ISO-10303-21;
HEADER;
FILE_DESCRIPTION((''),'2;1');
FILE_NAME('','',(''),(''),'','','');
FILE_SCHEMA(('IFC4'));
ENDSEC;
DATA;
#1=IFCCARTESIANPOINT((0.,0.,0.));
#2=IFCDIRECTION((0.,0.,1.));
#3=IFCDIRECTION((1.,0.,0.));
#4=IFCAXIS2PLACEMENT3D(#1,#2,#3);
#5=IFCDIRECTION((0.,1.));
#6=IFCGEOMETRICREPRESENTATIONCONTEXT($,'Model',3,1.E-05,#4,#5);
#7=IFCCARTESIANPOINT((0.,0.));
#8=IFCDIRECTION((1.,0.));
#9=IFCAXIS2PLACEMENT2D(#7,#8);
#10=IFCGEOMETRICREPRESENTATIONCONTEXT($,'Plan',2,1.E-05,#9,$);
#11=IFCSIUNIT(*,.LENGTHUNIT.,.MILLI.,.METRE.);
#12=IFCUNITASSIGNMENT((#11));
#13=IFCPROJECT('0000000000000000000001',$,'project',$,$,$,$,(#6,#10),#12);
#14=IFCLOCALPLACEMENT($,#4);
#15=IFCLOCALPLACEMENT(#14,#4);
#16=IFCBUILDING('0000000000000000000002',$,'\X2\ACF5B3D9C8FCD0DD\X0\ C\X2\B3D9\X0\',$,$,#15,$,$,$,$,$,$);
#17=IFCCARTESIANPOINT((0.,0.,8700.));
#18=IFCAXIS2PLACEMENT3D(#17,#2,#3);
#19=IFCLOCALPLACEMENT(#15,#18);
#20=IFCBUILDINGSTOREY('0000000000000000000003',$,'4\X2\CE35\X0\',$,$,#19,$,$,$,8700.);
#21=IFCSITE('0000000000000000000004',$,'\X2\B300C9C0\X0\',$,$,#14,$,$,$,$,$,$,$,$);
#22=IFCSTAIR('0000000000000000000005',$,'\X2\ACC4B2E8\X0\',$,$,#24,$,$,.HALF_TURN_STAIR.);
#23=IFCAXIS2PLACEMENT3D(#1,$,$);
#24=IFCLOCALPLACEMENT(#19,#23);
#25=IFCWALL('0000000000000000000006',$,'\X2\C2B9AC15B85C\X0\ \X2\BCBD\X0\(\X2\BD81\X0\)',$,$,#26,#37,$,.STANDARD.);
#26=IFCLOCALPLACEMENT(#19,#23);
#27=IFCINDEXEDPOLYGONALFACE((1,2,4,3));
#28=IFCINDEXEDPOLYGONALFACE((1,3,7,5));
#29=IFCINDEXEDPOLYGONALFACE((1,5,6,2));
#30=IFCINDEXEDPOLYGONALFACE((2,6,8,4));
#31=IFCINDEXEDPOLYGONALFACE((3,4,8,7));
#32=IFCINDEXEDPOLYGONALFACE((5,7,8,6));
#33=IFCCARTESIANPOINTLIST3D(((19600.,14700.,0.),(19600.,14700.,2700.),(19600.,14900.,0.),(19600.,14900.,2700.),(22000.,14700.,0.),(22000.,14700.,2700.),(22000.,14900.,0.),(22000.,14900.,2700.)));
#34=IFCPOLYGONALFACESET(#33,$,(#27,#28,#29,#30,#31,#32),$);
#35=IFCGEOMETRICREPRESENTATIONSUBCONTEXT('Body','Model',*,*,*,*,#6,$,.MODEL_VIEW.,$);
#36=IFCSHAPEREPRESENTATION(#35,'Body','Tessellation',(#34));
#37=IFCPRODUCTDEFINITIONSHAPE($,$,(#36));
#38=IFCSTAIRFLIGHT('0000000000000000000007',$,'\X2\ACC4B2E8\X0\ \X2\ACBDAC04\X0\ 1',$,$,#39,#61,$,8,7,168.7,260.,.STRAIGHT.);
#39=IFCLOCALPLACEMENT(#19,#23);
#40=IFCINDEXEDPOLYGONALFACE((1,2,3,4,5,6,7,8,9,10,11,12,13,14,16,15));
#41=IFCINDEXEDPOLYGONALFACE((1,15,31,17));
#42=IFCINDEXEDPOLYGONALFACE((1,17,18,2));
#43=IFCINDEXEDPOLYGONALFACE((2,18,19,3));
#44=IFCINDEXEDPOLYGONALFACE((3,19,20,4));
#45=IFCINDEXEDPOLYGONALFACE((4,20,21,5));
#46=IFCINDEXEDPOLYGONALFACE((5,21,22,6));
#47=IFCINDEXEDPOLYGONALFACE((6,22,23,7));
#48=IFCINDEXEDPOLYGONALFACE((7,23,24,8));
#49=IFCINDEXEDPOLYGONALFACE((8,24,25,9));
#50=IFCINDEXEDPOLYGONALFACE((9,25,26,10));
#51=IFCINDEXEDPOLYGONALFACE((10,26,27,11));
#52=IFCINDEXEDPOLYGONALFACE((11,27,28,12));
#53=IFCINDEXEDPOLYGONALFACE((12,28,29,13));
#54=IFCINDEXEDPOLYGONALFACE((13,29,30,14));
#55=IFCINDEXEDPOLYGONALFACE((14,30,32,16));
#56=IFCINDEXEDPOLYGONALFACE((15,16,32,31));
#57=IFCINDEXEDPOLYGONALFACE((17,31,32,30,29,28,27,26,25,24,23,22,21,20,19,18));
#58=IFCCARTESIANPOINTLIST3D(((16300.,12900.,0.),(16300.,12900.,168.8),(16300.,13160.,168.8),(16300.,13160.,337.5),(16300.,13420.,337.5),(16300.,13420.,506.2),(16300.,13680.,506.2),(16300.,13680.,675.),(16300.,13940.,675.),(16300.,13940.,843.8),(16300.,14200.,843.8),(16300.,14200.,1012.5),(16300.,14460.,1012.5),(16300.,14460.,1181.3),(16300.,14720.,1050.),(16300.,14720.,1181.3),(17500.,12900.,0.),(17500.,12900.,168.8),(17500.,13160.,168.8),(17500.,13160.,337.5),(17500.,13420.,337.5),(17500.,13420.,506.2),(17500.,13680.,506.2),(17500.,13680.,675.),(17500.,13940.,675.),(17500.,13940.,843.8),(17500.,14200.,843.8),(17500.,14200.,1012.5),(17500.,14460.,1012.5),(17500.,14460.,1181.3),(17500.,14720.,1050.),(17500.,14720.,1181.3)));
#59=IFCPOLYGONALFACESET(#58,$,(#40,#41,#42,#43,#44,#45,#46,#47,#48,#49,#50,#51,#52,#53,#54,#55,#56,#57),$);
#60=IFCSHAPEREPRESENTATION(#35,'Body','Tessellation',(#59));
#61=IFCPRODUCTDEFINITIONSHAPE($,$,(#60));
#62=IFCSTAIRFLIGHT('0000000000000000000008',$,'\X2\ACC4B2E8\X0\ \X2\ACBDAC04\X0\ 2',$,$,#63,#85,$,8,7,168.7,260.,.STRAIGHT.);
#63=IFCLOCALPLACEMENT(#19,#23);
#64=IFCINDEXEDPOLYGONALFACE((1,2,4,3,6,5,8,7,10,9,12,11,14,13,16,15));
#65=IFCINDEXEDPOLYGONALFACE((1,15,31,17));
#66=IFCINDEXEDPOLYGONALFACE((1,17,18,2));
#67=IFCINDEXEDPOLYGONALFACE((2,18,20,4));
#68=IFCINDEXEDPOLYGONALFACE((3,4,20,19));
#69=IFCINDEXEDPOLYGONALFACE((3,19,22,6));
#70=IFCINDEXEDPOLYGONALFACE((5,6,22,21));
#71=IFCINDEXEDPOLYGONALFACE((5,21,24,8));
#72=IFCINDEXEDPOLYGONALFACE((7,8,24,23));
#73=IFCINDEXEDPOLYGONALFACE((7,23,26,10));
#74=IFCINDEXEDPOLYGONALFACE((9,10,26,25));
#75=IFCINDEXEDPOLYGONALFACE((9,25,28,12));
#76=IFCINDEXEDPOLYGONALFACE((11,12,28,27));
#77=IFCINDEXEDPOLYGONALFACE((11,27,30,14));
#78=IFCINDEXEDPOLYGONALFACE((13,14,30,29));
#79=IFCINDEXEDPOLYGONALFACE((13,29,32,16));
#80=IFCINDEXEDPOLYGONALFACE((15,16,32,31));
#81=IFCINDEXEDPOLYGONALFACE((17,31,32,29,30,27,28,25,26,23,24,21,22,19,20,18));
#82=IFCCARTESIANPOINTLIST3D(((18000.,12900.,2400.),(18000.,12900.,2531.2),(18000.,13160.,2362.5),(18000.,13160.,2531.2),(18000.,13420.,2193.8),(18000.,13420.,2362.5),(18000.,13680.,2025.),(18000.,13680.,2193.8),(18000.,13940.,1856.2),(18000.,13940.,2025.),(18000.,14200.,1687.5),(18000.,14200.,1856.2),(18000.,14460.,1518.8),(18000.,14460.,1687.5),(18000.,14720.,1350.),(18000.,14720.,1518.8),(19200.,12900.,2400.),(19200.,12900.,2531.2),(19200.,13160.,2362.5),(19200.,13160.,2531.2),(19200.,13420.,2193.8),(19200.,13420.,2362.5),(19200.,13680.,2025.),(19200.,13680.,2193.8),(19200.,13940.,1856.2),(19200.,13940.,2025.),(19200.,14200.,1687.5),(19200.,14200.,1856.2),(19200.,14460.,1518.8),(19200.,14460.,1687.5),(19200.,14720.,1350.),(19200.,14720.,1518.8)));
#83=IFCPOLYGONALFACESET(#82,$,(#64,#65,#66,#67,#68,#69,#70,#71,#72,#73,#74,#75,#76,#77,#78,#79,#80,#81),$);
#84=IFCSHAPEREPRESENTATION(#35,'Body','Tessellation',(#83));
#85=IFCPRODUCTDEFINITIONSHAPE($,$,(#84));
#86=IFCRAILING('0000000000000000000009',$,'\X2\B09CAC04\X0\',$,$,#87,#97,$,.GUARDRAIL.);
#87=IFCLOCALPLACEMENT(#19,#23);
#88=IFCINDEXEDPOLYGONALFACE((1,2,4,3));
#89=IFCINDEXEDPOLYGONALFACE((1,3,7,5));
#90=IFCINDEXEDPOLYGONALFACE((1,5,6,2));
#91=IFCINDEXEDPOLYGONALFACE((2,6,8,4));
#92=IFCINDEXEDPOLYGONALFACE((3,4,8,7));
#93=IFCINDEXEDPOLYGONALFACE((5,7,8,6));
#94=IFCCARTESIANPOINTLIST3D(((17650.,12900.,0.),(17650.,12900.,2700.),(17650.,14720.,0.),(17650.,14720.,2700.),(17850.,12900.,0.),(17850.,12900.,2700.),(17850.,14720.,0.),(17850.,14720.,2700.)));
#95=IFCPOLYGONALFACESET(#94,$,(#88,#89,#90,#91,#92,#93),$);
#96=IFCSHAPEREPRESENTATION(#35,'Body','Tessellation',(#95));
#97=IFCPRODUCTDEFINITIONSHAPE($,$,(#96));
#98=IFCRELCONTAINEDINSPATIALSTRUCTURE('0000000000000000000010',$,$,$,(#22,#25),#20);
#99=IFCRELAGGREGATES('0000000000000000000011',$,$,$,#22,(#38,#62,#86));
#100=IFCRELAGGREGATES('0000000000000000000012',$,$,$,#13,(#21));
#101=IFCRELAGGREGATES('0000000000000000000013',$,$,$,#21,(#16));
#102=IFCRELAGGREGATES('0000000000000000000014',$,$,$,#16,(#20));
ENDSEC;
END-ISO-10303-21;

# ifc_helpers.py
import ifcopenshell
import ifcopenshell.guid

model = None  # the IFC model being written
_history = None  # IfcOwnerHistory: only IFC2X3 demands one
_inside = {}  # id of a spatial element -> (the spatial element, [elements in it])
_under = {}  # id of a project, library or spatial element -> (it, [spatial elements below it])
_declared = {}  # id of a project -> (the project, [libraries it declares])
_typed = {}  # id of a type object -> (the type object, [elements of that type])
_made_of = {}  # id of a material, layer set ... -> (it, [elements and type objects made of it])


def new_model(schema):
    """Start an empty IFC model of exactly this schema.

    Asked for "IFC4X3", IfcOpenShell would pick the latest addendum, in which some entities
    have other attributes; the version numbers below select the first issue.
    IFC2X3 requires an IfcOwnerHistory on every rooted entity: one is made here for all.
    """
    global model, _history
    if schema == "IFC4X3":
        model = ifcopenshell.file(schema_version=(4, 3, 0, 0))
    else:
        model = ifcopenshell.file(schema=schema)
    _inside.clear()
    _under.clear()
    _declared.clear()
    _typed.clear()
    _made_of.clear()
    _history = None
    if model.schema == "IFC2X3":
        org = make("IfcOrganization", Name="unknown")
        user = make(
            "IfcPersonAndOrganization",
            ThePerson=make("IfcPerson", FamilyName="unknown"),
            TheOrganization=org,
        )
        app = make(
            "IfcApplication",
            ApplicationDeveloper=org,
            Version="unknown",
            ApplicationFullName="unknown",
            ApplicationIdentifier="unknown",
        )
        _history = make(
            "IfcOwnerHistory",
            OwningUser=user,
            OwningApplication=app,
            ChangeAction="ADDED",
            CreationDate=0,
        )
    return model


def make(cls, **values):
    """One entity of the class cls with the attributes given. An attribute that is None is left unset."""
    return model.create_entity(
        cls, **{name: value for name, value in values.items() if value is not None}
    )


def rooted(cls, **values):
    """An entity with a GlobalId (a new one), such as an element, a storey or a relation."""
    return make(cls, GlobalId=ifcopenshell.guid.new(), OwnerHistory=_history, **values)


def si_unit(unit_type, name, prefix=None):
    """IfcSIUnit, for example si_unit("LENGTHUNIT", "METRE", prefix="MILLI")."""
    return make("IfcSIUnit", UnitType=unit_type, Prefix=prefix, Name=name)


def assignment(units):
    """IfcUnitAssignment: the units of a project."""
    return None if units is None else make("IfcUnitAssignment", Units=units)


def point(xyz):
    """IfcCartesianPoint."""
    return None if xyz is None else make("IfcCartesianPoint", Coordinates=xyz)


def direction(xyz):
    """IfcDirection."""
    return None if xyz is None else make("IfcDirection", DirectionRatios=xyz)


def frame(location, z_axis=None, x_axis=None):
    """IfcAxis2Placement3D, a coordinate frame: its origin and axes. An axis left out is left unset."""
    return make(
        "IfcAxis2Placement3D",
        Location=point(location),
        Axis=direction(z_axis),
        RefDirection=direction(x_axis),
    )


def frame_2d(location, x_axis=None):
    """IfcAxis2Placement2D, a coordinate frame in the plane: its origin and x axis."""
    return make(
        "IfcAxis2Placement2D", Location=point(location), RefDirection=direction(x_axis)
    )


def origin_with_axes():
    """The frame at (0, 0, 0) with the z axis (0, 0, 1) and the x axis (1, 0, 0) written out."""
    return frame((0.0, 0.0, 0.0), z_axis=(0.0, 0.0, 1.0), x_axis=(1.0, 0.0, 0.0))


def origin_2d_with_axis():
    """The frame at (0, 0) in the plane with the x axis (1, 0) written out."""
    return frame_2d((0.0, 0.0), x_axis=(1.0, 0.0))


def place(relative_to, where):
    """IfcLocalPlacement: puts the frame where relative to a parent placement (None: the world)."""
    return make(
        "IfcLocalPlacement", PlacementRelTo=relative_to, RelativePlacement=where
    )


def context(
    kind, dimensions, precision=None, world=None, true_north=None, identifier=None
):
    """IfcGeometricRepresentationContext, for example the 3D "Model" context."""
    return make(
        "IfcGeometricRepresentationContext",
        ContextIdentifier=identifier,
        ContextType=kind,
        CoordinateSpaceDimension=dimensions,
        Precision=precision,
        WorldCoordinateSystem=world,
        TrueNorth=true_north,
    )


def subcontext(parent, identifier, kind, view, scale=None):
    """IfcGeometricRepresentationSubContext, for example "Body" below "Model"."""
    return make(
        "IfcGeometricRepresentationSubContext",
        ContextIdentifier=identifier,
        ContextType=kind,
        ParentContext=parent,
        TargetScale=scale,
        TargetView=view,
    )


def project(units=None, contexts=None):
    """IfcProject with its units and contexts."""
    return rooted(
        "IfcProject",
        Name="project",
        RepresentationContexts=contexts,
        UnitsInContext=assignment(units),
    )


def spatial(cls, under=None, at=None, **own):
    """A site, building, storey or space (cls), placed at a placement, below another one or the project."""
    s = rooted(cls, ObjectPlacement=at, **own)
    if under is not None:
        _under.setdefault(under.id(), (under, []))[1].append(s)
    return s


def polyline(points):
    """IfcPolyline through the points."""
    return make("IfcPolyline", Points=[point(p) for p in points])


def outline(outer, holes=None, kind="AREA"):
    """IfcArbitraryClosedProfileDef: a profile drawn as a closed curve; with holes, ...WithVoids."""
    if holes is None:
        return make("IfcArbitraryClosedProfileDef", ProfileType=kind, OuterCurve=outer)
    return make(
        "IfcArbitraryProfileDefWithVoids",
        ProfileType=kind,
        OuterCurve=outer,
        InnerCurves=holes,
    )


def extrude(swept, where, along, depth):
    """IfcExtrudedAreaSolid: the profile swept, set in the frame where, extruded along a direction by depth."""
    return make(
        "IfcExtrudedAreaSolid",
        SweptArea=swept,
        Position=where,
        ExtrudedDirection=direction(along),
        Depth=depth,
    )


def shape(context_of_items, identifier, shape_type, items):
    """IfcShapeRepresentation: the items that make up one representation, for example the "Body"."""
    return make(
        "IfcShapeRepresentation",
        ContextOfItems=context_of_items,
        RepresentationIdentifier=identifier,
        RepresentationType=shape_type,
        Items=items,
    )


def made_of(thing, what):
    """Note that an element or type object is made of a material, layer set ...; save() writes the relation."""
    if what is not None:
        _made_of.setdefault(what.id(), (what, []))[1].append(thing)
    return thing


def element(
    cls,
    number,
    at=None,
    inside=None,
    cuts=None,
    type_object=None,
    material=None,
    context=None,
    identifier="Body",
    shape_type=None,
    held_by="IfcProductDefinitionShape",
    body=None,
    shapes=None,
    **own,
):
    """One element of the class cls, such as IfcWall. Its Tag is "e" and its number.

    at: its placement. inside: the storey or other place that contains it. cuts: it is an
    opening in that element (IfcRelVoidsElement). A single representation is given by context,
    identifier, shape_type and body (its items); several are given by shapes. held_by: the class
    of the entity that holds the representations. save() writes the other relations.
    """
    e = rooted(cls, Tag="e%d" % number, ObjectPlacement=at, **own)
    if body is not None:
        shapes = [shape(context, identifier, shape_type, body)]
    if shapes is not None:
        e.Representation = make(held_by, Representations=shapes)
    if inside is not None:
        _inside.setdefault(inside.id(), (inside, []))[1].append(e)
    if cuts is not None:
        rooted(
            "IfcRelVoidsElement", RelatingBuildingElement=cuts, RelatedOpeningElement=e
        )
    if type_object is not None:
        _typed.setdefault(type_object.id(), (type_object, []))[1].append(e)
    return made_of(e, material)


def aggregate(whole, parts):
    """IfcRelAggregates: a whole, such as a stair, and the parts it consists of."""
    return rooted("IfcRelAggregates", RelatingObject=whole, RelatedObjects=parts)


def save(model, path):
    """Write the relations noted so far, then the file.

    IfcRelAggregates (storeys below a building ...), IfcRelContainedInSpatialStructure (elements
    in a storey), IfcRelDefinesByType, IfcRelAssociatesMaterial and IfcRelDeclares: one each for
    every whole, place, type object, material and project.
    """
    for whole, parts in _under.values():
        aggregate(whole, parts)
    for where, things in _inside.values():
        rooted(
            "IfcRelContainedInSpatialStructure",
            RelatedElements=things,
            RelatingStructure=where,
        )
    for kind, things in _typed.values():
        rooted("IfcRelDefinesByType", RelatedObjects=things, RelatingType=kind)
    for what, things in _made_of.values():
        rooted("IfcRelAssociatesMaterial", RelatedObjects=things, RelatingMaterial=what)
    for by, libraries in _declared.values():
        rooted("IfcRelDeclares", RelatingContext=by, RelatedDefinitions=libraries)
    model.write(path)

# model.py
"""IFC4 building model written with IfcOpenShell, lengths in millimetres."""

from ifc_helpers import new_model, si_unit, direction, frame, origin_with_axes, origin_2d_with_axis, place, context, subcontext, project, spatial, polyline, outline, extrude, element, aggregate, save


model = new_model("IFC4")

# Units and contexts
model_context = context("Model", 3, precision=1e-05, world=origin_with_axes(), true_north=direction((0.0, 1.0)))
plan_context = context("Plan", 2, precision=1e-05, world=origin_2d_with_axis())
body_context = subcontext(model_context, "Body", "Model", "MODEL_VIEW")
ifc_project = project(units=[si_unit("LENGTHUNIT", "METRE", prefix="MILLI")], contexts=[model_context, plan_context])

# Site, building, storey
site_placement = place(None, origin_with_axes())
site = spatial("IfcSite", under=ifc_project, at=site_placement, Name="대지")
building_placement = place(site_placement, origin_with_axes())
building = spatial("IfcBuilding", under=site, at=building_placement, Name="공동주택 C동")
storey_placement = place(building_placement, frame((0.0, 0.0, 8700.0), z_axis=(0.0, 0.0, 1.0), x_axis=(1.0, 0.0, 0.0)))
storey = spatial("IfcBuildingStorey", under=building, at=storey_placement, Name="4층", Elevation=8700.0)

# Stair
stair_placement = place(storey_placement, origin_with_axes())
stair = element("IfcStair", 1, at=stair_placement, inside=storey, Name="계단", PredefinedType="HALF_TURN_STAIR")

# Wall
wall_1_placement = place(storey_placement, origin_with_axes())
element("IfcWall", 2, at=wall_1_placement, inside=storey, Name="승강로 벽(북)", PredefinedType="STANDARD", context=body_context, shape_type="SweptSolid", body=[
    extrude(outline(polyline([(19600.0, 14900.0), (22000.0, 14900.0), (22000.0, 14700.0), (19600.0, 14700.0), (19600.0, 14900.0)])), origin_with_axes(), (0.0, 0.0, 1.0), 2700.0),
])

# Stair flights
stair_flight_1_placement = place(stair_placement, origin_with_axes())
stair_flight_1 = element("IfcStairFlight", 3, at=stair_flight_1_placement, Name="계단 경간 1", NumberOfRisers=8, NumberOfTreads=7, PredefinedType="STRAIGHT", RiserHeight=168.7, TreadLength=260.0, context=body_context, shape_type="SweptSolid", body=[
    extrude(outline(polyline([(0.0, 0.0), (0.0, 168.7), (260.0, 168.7), (260.0, 337.5), (520.0, 337.5), (520.0, 506.2), (780.0, 506.2), (780.0, 675.0), (1040.0, 675.0), (1040.0, 843.7), (1300.0, 843.7), (1300.0, 1012.5), (1560.0, 1012.5), (1560.0, 1181.2), (1820.0, 1181.2), (1820.0, 1350.0), (1820.0, 1050.0), (0.0, 0.0)])), frame((16300.0, 12900.0, 0.0), z_axis=(1.0, 0.0, 0.0), x_axis=(0.0, 1.0, 0.0)), (0.0, 0.0, 1.0), 1200.0),
])
stair_flight_2_placement = place(stair_placement, origin_with_axes())
stair_flight_2 = element("IfcStairFlight", 4, at=stair_flight_2_placement, Name="계단 경간 2", NumberOfRisers=8, NumberOfTreads=7, PredefinedType="STRAIGHT", RiserHeight=168.7, TreadLength=260.0, context=body_context, shape_type="SweptSolid", body=[
    extrude(outline(polyline([(0.0, 0.0), (0.0, 168.7), (260.0, 168.7), (260.0, 337.5), (520.0, 337.5), (520.0, 506.2), (780.0, 506.2), (780.0, 675.0), (1040.0, 675.0), (1040.0, 843.7), (1300.0, 843.7), (1300.0, 1012.5), (1560.0, 1012.5), (1560.0, 1181.2), (1820.0, 1181.2), (1820.0, 1350.0), (1820.0, 1050.0), (0.0, 0.0)])), frame((19200.0, 14720.0, 1350.0), z_axis=(-1.0, 0.0, 0.0), x_axis=(0.0, -1.0, 0.0)), (0.0, 0.0, 1.0), 1200.0),
])

# Railing
railing_placement = place(stair_placement, origin_with_axes())
railing = element("IfcRailing", 5, at=railing_placement, Name="난간", PredefinedType="GUARDRAIL", context=body_context, shape_type="SweptSolid", body=[
    extrude(outline(polyline([(17650.0, 12900.0), (17850.0, 12900.0), (17850.0, 14720.0), (17650.0, 14720.0), (17650.0, 12900.0)])), origin_with_axes(), (0.0, 0.0, 1.0), 2700.0),
])
aggregate(stair, [stair_flight_1, stair_flight_2, railing])

save(model, "model.ifc")
